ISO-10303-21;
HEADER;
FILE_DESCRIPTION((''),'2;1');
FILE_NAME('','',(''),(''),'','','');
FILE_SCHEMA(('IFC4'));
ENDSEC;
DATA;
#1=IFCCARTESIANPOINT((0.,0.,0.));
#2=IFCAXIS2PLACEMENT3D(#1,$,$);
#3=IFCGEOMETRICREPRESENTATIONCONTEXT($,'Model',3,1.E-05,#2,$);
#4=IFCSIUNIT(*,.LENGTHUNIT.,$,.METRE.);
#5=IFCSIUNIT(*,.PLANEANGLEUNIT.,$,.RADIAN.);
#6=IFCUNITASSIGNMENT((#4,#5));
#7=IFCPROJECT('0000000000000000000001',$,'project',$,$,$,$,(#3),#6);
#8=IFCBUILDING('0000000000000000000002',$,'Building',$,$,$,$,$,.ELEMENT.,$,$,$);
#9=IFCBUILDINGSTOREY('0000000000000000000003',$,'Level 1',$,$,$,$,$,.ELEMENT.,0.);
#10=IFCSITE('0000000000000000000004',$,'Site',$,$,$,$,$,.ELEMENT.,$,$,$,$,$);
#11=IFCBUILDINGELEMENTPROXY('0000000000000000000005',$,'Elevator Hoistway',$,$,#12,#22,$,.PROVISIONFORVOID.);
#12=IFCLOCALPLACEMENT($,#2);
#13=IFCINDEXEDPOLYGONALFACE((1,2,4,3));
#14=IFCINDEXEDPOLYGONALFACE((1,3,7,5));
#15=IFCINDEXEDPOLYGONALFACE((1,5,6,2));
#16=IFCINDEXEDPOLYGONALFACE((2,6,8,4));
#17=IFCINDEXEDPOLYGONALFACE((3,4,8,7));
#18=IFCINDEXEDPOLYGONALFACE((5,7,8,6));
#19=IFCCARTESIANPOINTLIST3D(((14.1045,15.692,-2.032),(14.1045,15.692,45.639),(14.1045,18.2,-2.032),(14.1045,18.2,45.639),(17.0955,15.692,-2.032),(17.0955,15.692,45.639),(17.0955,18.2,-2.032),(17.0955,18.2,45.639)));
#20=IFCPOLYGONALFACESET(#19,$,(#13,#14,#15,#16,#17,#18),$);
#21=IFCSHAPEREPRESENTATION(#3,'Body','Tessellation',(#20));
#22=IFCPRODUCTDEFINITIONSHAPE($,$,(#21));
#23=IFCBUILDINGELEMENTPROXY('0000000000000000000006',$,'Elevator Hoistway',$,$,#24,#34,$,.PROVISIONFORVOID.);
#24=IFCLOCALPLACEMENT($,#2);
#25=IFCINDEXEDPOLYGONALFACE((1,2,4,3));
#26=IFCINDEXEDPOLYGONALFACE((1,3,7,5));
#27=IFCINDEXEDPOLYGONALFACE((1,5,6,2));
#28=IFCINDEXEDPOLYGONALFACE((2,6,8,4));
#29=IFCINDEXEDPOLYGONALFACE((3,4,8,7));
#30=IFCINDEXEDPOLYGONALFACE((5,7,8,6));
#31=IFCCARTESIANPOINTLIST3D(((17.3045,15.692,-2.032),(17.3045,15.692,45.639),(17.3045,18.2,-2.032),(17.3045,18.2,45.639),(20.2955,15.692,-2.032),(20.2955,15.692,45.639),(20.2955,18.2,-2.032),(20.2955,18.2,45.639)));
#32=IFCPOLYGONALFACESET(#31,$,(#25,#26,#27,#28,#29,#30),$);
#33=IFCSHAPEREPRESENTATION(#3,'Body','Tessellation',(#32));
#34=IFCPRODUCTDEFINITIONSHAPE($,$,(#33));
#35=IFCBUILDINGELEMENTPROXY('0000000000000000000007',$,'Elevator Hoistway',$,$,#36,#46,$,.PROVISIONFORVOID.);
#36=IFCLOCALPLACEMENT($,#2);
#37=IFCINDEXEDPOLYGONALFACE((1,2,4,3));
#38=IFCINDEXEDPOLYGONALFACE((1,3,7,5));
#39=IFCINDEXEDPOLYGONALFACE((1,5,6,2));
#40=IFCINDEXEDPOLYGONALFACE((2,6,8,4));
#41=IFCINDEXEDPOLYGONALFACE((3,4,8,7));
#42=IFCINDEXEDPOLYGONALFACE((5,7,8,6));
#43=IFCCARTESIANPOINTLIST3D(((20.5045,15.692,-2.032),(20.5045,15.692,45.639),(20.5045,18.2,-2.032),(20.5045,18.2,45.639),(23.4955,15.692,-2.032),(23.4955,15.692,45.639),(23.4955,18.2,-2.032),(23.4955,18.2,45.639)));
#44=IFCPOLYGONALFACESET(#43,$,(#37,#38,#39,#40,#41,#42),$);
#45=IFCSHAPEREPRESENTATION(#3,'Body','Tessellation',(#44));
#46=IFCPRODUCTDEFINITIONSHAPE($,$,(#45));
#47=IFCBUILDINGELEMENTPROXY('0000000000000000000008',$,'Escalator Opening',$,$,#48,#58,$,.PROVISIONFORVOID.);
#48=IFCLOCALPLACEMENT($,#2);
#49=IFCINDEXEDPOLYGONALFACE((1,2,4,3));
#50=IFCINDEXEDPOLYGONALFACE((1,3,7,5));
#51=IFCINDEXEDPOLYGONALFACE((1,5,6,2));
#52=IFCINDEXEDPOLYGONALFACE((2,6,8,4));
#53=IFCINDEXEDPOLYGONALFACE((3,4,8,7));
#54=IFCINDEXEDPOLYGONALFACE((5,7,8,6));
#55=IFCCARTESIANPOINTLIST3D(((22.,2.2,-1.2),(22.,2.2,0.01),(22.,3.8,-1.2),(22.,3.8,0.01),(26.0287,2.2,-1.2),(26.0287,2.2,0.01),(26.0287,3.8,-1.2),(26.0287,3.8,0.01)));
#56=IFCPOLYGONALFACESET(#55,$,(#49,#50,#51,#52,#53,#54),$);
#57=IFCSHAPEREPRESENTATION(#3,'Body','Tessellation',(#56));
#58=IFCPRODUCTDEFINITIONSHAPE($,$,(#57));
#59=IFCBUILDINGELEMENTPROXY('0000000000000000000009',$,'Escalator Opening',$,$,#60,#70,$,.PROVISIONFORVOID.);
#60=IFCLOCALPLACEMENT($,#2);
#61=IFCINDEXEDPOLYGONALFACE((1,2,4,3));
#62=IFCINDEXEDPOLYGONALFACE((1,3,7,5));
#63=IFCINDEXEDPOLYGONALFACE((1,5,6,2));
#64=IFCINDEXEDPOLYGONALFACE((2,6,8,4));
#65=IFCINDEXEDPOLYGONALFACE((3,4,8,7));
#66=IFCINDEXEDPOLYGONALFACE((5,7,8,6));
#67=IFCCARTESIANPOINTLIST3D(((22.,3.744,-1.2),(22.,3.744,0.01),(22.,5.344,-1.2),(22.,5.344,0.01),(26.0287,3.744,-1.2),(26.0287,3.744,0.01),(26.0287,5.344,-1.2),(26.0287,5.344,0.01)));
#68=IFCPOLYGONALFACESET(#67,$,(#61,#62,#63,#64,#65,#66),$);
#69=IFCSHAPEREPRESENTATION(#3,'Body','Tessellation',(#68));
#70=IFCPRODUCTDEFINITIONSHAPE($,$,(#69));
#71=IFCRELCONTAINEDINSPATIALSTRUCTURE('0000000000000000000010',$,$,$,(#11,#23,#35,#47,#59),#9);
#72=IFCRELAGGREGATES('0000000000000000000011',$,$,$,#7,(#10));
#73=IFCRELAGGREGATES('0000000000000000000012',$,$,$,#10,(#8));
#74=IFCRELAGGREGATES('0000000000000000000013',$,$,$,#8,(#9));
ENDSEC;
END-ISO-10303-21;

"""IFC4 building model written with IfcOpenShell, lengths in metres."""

from ifc_helpers import new_model, si_unit, frame, origin, place, context, project, spatial, polyline, outline, extrude, element, save


model = new_model("IFC4")

# Units and contexts
model_context = context("Model", 3, precision=1e-05, world=origin())
ifc_project = project(units=[si_unit("LENGTHUNIT", "METRE"), si_unit("PLANEANGLEUNIT", "RADIAN")], contexts=[model_context])

# Site, building, storey
site = spatial("IfcSite", under=ifc_project, Name="Site", CompositionType="ELEMENT")
building = spatial("IfcBuilding", under=site, Name="Building", CompositionType="ELEMENT")
storey = spatial("IfcBuildingStorey", under=building, Name="Level 1", CompositionType="ELEMENT", Elevation=0.0)

# Building element proxies
proxy_1_placement = place(None, frame((0.0, 0.0, 45.639)))
element("IfcBuildingElementProxy", 1, at=proxy_1_placement, inside=storey, Name="Elevator Hoistway", PredefinedType="PROVISIONFORVOID", context=model_context, shape_type="SweptSolid", body=[
    extrude(outline(polyline([(17.0955, 18.2), (14.1045, 18.2), (14.1045, 15.692), (17.0955, 15.692), (17.0955, 18.2)])), origin(), (0.0, 0.0, -1.0), 47.671),
])
proxy_2_placement = place(None, frame((0.0, 0.0, 45.639)))
element("IfcBuildingElementProxy", 2, at=proxy_2_placement, inside=storey, Name="Elevator Hoistway", PredefinedType="PROVISIONFORVOID", context=model_context, shape_type="SweptSolid", body=[
    extrude(outline(polyline([(20.2955, 18.2), (17.3045, 18.2), (17.3045, 15.692), (20.2955, 15.692), (20.2955, 18.2)])), origin(), (0.0, 0.0, -1.0), 47.671),
])
proxy_3_placement = place(None, frame((0.0, 0.0, 45.639)))
element("IfcBuildingElementProxy", 3, at=proxy_3_placement, inside=storey, Name="Elevator Hoistway", PredefinedType="PROVISIONFORVOID", context=model_context, shape_type="SweptSolid", body=[
    extrude(outline(polyline([(23.4955, 18.2), (20.5045, 18.2), (20.5045, 15.692), (23.4955, 15.692), (23.4955, 18.2)])), origin(), (0.0, 0.0, -1.0), 47.671),
])
proxy_4_placement = place(None, frame((0.0, 0.0, 0.01)))
element("IfcBuildingElementProxy", 4, at=proxy_4_placement, inside=storey, Name="Escalator Opening", PredefinedType="PROVISIONFORVOID", context=model_context, shape_type="SweptSolid", body=[
    extrude(outline(polyline([(22.0, 2.2), (26.0287, 2.2), (26.0287, 3.8), (22.0, 3.8), (22.0, 2.2)])), origin(), (0.0, 0.0, -1.0), 1.21),
])
proxy_5_placement = place(None, frame((0.0, 0.0, 0.01)))
element("IfcBuildingElementProxy", 5, at=proxy_5_placement, inside=storey, Name="Escalator Opening", PredefinedType="PROVISIONFORVOID", context=model_context, shape_type="SweptSolid", body=[
    extrude(outline(polyline([(22.0, 3.744), (26.0287, 3.744), (26.0287, 5.344), (22.0, 5.344), (22.0, 3.744)])), origin(), (0.0, 0.0, -1.0), 1.21),
])

save(model, "model.ifc")
